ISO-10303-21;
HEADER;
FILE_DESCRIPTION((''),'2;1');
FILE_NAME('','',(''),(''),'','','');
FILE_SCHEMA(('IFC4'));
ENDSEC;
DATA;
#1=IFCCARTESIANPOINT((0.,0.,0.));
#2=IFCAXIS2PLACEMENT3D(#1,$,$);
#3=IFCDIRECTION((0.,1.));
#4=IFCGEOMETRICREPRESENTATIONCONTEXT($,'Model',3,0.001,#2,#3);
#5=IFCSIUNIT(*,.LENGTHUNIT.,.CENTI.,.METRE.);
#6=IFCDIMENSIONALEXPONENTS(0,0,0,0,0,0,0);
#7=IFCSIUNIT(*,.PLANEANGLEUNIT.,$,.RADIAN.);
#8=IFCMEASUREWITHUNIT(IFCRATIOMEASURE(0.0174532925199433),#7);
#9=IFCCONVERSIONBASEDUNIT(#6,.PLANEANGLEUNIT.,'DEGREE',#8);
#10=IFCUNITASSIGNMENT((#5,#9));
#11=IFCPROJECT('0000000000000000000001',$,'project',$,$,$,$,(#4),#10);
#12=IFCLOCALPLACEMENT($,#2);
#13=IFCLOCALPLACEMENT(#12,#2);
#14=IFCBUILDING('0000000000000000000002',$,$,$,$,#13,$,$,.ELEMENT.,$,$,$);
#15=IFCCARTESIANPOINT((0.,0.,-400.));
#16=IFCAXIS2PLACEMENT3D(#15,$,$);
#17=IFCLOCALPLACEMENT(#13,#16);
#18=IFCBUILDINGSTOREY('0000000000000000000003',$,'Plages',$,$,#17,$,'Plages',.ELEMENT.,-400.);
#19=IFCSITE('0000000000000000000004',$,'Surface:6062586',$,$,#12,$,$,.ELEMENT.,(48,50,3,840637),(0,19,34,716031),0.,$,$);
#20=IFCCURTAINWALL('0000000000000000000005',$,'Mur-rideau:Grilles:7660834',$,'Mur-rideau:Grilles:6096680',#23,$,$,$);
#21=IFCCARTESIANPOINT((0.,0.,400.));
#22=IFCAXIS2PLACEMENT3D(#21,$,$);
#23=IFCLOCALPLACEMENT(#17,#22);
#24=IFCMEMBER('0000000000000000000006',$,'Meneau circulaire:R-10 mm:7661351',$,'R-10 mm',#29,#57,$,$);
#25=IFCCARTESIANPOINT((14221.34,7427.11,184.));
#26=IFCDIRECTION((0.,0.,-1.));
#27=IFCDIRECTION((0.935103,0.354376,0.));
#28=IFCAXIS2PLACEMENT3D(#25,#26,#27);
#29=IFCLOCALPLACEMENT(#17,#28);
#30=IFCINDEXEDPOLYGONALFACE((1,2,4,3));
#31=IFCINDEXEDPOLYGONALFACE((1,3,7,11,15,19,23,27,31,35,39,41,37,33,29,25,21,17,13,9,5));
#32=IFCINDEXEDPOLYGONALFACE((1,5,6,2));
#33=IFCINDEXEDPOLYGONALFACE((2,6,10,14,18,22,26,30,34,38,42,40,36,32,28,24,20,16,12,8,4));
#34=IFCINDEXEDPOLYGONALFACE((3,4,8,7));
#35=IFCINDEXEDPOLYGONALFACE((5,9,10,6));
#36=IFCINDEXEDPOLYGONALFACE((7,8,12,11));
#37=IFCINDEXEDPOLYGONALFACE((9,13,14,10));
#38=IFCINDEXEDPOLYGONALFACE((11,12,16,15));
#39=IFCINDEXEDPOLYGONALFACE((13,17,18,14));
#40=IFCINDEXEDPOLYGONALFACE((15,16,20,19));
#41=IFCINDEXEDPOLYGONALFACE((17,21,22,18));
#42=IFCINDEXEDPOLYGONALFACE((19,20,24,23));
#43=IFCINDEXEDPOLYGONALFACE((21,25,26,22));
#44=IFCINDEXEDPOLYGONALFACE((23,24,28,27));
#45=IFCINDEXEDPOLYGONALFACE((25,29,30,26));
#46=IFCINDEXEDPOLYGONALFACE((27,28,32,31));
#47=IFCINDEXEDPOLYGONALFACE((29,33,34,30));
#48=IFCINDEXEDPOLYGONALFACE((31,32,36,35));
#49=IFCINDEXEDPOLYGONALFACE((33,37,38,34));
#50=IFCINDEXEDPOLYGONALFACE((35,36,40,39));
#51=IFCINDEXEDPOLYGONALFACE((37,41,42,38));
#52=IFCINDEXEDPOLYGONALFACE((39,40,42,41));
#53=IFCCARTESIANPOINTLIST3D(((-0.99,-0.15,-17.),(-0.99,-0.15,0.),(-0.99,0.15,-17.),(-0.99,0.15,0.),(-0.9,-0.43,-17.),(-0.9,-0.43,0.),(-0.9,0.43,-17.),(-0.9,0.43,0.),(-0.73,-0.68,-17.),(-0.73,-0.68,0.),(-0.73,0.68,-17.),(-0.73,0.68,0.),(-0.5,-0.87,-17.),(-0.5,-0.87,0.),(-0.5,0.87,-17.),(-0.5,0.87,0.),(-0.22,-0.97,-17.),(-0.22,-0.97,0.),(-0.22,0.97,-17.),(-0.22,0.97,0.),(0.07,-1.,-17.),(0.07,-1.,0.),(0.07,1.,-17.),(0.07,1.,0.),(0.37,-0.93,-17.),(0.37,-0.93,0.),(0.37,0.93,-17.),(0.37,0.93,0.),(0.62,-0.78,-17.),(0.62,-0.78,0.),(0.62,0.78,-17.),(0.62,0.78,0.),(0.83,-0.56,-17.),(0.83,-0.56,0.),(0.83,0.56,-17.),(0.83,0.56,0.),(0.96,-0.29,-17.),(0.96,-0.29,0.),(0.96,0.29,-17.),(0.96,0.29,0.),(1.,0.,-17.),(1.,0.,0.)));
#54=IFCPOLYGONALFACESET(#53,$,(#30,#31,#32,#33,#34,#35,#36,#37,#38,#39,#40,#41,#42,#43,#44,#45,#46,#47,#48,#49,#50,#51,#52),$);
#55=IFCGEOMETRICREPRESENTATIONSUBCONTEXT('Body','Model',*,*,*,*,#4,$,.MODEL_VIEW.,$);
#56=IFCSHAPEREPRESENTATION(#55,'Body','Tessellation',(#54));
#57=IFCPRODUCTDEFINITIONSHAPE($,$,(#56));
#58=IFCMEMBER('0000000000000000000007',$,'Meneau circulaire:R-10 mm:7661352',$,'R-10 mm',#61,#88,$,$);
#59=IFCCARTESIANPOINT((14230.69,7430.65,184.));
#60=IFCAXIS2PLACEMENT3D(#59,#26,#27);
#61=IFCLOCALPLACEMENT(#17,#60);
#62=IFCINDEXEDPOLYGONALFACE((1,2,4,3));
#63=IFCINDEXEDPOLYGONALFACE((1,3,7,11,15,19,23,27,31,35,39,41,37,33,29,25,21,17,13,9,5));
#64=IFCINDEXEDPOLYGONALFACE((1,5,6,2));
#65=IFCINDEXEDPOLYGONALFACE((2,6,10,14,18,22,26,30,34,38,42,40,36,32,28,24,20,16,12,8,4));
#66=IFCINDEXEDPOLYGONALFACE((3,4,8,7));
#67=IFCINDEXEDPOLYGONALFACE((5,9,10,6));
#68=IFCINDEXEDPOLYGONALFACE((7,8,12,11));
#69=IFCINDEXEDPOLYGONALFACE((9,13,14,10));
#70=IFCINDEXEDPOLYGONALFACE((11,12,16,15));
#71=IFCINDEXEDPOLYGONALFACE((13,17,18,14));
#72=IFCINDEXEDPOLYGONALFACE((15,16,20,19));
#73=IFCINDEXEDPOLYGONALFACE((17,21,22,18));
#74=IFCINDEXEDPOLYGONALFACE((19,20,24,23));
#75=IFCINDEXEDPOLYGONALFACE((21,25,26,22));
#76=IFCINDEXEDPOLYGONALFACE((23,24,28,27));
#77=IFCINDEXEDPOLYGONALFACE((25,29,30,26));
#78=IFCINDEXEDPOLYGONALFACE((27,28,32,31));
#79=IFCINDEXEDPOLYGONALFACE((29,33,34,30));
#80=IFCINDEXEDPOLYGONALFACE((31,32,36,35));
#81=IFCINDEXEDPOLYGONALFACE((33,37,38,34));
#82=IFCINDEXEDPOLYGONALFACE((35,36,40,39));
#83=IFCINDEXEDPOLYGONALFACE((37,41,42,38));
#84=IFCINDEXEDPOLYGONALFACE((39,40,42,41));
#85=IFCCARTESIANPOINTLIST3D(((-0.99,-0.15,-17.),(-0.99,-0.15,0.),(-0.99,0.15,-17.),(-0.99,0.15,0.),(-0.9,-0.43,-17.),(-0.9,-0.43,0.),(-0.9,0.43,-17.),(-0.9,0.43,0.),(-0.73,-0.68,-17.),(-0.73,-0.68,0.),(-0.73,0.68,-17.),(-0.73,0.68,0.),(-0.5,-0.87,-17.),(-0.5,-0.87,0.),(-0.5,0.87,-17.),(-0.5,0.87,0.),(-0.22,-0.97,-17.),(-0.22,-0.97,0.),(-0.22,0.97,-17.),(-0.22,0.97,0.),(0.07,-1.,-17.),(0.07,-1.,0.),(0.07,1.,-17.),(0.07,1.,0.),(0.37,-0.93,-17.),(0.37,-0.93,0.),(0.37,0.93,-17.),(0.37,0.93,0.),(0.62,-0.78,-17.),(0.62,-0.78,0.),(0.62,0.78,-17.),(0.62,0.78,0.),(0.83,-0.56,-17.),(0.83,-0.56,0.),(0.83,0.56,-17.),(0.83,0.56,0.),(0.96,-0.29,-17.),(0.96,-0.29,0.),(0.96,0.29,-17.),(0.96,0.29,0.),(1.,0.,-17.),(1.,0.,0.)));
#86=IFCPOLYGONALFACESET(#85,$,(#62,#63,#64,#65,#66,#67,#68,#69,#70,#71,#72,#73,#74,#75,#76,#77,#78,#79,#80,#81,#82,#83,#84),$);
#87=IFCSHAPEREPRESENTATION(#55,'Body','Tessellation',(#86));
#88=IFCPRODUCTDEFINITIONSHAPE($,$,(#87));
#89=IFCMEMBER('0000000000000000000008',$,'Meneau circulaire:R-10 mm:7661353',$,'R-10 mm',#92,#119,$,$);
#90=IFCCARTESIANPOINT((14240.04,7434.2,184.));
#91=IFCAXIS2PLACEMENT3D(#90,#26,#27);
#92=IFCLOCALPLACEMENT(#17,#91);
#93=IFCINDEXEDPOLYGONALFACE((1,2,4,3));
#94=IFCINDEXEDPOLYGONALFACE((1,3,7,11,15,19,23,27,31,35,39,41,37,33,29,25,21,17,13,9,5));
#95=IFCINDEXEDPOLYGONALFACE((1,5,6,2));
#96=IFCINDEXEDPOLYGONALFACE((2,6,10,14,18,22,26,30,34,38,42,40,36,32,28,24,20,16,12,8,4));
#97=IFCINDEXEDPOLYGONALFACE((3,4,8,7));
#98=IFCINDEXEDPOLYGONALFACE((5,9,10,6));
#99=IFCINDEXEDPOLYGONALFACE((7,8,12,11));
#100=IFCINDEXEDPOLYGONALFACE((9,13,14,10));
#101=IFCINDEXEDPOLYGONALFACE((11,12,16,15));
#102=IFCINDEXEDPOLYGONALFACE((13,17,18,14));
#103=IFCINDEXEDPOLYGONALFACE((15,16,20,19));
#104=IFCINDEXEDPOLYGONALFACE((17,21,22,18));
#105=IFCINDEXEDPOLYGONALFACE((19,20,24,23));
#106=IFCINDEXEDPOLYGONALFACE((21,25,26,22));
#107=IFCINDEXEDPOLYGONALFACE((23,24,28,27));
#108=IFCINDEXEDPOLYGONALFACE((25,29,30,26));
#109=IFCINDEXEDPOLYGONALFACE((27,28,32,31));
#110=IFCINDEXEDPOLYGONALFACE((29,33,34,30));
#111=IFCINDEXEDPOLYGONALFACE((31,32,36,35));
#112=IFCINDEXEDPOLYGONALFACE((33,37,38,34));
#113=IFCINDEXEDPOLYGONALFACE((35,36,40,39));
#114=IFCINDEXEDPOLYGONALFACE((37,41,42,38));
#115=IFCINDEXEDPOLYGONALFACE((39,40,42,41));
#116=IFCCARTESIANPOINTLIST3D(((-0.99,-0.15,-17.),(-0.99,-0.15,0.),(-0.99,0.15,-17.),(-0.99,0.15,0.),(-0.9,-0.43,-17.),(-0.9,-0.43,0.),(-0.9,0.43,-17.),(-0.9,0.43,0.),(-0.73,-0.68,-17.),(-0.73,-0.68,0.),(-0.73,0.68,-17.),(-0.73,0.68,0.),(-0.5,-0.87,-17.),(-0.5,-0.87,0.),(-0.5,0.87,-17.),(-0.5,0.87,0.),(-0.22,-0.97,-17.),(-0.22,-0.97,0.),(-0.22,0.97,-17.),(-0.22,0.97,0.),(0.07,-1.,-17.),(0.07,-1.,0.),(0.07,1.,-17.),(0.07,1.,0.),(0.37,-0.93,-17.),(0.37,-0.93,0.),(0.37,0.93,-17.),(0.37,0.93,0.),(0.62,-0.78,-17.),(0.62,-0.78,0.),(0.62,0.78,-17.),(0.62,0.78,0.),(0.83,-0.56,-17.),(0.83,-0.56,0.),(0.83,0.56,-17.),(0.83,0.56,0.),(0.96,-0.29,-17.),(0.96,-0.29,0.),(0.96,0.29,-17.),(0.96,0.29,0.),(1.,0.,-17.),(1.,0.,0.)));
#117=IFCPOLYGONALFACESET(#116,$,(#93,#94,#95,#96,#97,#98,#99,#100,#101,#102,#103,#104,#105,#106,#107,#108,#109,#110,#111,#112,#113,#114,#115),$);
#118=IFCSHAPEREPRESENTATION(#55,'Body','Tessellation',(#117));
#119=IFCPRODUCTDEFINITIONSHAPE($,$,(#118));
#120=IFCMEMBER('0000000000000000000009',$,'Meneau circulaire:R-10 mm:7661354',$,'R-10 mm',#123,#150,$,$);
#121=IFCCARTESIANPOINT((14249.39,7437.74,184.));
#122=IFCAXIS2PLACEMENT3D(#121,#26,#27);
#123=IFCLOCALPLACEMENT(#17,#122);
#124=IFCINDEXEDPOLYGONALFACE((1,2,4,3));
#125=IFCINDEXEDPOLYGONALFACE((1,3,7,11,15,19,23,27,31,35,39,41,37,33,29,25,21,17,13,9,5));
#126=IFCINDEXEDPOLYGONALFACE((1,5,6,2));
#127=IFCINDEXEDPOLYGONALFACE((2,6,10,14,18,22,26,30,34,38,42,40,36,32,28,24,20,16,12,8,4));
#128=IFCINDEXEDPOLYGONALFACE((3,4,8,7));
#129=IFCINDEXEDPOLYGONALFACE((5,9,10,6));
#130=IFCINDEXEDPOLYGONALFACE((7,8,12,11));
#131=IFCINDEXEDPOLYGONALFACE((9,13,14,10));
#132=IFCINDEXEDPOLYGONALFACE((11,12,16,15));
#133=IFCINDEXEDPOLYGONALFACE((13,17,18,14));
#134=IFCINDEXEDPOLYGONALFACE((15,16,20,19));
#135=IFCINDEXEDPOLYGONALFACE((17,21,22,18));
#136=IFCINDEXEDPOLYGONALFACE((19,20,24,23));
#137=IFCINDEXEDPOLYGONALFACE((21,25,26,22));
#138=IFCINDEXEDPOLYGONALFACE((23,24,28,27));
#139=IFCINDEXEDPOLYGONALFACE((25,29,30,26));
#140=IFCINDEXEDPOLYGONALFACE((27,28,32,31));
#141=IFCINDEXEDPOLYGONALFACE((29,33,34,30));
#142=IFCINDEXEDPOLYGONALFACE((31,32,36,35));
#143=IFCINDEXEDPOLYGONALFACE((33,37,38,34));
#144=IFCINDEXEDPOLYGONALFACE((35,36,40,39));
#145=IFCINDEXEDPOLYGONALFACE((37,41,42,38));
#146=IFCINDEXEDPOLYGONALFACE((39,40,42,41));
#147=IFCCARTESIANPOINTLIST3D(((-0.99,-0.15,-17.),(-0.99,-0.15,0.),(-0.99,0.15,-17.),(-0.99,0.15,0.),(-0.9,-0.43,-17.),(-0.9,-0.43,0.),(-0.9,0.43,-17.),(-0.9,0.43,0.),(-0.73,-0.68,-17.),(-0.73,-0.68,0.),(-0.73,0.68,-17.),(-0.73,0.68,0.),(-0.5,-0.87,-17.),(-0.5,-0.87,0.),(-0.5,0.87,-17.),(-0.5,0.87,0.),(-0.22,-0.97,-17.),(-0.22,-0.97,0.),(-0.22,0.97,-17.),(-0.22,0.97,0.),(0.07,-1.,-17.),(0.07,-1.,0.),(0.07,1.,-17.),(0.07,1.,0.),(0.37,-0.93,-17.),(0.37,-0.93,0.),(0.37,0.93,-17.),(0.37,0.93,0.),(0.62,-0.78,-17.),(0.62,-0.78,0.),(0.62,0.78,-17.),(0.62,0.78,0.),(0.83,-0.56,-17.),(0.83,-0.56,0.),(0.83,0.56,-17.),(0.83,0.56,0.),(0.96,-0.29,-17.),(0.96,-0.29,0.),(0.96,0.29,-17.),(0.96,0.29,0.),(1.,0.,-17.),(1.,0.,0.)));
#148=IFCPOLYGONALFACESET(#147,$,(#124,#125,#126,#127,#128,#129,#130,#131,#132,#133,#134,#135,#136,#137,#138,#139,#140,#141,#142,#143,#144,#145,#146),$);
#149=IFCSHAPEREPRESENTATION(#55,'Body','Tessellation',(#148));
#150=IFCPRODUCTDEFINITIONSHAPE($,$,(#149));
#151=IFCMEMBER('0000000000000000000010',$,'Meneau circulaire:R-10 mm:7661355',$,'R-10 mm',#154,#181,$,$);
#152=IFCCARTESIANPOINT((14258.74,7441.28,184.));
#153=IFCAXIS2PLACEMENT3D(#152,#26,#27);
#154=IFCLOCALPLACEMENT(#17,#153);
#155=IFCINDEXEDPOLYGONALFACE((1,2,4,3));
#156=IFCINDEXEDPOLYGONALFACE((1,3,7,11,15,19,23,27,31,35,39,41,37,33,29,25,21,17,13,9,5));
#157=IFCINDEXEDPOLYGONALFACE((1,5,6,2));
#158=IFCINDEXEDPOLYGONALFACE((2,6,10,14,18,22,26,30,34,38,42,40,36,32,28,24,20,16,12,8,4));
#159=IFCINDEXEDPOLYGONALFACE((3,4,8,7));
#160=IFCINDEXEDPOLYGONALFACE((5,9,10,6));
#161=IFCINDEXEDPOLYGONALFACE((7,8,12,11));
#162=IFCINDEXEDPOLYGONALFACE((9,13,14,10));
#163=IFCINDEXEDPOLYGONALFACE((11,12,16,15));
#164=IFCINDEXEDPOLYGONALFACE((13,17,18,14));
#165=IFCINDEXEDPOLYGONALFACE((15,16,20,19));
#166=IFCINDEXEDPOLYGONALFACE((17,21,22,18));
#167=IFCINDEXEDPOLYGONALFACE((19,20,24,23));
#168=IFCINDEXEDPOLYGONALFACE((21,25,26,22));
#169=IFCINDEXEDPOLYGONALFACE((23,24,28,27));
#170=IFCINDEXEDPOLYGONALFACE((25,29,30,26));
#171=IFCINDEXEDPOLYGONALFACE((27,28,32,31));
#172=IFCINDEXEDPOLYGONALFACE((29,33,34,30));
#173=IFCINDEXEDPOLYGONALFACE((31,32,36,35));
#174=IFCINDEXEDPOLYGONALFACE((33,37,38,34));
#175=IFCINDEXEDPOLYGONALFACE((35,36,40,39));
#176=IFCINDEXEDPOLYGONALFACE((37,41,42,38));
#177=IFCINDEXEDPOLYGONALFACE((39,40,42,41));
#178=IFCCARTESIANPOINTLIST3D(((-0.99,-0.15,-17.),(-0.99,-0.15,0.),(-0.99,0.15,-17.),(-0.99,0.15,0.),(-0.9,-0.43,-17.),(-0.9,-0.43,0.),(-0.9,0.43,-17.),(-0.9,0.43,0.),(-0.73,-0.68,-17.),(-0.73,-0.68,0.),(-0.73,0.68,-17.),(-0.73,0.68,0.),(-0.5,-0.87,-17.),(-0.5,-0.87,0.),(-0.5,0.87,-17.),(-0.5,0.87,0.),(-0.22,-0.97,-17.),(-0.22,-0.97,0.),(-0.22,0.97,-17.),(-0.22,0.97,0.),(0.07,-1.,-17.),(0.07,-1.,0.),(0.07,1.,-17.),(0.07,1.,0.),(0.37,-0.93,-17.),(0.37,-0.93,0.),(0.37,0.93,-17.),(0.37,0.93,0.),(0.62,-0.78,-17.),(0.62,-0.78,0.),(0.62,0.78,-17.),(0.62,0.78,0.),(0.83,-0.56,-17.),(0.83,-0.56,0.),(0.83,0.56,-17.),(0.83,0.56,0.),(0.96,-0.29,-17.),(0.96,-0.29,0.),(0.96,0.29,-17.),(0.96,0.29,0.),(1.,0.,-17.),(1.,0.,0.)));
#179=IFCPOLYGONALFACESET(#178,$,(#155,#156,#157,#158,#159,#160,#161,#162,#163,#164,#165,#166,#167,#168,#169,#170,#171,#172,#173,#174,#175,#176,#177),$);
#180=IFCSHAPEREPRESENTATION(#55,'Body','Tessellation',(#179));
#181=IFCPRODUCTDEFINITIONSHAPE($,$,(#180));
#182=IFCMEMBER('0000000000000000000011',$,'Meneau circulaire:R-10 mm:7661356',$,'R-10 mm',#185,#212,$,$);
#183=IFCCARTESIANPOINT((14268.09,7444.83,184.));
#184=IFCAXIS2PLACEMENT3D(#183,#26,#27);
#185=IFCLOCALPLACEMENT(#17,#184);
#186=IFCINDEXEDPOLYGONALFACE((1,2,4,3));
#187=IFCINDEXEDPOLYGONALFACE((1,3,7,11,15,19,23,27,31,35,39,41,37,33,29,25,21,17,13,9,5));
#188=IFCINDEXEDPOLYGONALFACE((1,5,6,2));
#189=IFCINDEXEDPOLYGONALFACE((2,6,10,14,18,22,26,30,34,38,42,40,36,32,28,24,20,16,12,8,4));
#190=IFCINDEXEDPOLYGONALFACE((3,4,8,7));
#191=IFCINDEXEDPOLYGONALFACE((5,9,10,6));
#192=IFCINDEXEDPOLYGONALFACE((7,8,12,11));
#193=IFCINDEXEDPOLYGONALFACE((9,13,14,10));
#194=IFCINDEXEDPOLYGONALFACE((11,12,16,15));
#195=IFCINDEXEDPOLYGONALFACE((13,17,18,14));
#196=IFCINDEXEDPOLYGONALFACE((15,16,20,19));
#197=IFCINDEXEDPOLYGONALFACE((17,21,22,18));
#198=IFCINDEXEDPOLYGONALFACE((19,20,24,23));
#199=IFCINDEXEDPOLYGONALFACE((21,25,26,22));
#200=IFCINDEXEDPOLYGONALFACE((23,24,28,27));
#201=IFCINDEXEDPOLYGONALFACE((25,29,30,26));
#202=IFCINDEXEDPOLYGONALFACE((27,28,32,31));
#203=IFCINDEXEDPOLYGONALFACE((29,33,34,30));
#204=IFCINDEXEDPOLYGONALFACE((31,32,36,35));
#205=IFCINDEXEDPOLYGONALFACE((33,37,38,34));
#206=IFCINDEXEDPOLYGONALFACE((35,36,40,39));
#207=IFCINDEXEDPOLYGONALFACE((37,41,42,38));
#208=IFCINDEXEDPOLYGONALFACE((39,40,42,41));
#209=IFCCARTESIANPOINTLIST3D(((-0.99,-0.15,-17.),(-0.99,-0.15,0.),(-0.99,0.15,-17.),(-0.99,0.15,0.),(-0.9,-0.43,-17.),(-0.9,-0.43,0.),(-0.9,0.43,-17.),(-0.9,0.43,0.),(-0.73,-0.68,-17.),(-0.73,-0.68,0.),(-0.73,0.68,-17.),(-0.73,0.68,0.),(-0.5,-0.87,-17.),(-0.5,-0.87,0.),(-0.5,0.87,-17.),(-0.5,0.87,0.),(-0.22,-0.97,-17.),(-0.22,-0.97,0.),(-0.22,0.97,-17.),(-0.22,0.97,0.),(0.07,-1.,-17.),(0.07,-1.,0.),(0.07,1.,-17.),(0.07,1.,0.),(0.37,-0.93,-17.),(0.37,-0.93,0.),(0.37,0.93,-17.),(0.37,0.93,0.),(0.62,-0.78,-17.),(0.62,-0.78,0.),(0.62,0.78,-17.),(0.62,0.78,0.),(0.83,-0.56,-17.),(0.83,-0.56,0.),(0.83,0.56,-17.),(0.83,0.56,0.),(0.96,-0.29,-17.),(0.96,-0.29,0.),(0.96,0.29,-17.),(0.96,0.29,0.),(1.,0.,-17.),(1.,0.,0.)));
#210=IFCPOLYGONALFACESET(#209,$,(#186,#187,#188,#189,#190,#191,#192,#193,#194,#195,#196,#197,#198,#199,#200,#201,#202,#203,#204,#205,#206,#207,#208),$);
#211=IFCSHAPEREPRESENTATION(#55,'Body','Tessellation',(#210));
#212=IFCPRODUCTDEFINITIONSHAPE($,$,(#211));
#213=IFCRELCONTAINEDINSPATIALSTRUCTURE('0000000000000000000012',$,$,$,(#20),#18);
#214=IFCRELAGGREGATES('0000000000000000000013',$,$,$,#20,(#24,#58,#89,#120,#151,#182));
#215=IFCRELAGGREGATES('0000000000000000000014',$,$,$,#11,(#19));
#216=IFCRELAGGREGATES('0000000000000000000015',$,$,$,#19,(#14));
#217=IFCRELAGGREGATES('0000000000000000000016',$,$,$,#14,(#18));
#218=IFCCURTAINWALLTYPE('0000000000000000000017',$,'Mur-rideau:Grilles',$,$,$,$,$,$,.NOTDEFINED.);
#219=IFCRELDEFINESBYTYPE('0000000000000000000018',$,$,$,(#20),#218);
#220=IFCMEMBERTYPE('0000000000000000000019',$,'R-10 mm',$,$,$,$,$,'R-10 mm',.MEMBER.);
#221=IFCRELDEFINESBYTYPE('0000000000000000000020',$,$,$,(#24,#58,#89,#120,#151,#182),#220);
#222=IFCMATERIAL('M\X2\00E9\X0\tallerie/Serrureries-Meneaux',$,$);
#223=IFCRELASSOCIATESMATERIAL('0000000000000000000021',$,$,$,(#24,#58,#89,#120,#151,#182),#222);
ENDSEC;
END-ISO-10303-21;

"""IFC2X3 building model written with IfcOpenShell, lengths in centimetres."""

from ifc_helpers import new_model, entity, si_unit, converted_unit, direction, frame, frame_2d, origin, place, context, subcontext, project, spatial, circle, extrude, source, transform, mapped, material, type_object, type_shapes, element, aggregate, save


model = new_model("IFC2X3")

# Units and contexts
model_context = context("Model", 3, precision=0.001, world=origin(), true_north=direction((0.0, 1.0)))
body_context = subcontext(model_context, "Body", "Model", "MODEL_VIEW")
ifc_project = project(units=[si_unit("LENGTHUNIT", "METRE", prefix="CENTI"), converted_unit("PLANEANGLEUNIT", "DEGREE", entity("IfcRatioMeasure", 0.0174532925199433), si_unit("PLANEANGLEUNIT", "RADIAN"), dimensions=[0, 0, 0, 0, 0, 0, 0])], contexts=[model_context])

# Site, building, storey
site_placement = place(None, origin())
site = spatial("IfcSite", under=ifc_project, at=site_placement, Name="Surface:6062586", CompositionType="ELEMENT", RefLatitude=(48, 50, 3, 840637), RefLongitude=(0, 19, 34, 716031), RefElevation=0.0)
building_placement = place(site_placement, origin())
building = spatial("IfcBuilding", under=site, at=building_placement, CompositionType="ELEMENT")
storey_placement = place(building_placement, frame((0.0, 0.0, -400.0)))
storey = spatial("IfcBuildingStorey", under=building, at=storey_placement, Name="Plages", LongName="Plages", CompositionType="ELEMENT", Elevation=-400.0)

# Curtain wall, members
curtain_wall_type = type_object("IfcCurtainWallType", Name="Mur-rideau:Grilles", PredefinedType="NOTDEFINED")
curtain_wall_placement = place(storey_placement, frame((0.0, 0.0, 400.0)))
curtain_wall = element("IfcCurtainWall", 1, at=curtain_wall_placement, inside=storey, type_object=curtain_wall_type, Name="Mur-rideau:Grilles:7660834", ObjectType="Mur-rideau:Grilles:6096680")
ifc_material = material(Name="Métallerie/Serrureries-Meneaux")
member_type_1 = type_object("IfcMemberType", Name="R-10 mm", ElementType="R-10 mm", PredefinedType="MEMBER")
shared_shape_1 = source(origin(), body_context, "Body", "SweptSolid", [
    extrude(circle(Radius=1.0, at=frame_2d((0.0, 0.0), x_axis=(1.0, 0.0))), frame((0.0, 0.0, -17.0)), (0.0, 0.0, 1.0), 17.0),
])
type_shapes(member_type_1, [shared_shape_1])
member_1_placement = place(storey_placement, frame((14221.34, 7427.11, 184.0), z_axis=(0.0, 0.0, -1.0), x_axis=(0.935103, 0.354376, 0.0)))
member_1 = element("IfcMember", 2, at=member_1_placement, type_object=member_type_1, material=ifc_material, Name="Meneau circulaire:R-10 mm:7661351", ObjectType="R-10 mm", context=body_context, shape_type="MappedRepresentation", body=[
    mapped(shared_shape_1, transform((0.0, 0.0, 0.0), scale=1.0)),
])
member_2_placement = place(storey_placement, frame((14230.69, 7430.65, 184.0), z_axis=(0.0, 0.0, -1.0), x_axis=(0.935103, 0.354376, 0.0)))
member_2 = element("IfcMember", 3, at=member_2_placement, type_object=member_type_1, material=ifc_material, Name="Meneau circulaire:R-10 mm:7661352", ObjectType="R-10 mm", context=body_context, shape_type="MappedRepresentation", body=[
    mapped(shared_shape_1, transform((0.0, 0.0, 0.0), scale=1.0)),
])
member_3_placement = place(storey_placement, frame((14240.04, 7434.2, 184.0), z_axis=(0.0, 0.0, -1.0), x_axis=(0.935103, 0.354376, 0.0)))
member_3 = element("IfcMember", 4, at=member_3_placement, type_object=member_type_1, material=ifc_material, Name="Meneau circulaire:R-10 mm:7661353", ObjectType="R-10 mm", context=body_context, shape_type="MappedRepresentation", body=[
    mapped(shared_shape_1, transform((0.0, 0.0, 0.0), scale=1.0)),
])
member_4_placement = place(storey_placement, frame((14249.39, 7437.74, 184.0), z_axis=(0.0, 0.0, -1.0), x_axis=(0.935103, 0.354376, 0.0)))
member_4 = element("IfcMember", 5, at=member_4_placement, type_object=member_type_1, material=ifc_material, Name="Meneau circulaire:R-10 mm:7661354", ObjectType="R-10 mm", context=body_context, shape_type="MappedRepresentation", body=[
    mapped(shared_shape_1, transform((0.0, 0.0, 0.0), scale=1.0)),
])
member_5_placement = place(storey_placement, frame((14258.74, 7441.28, 184.0), z_axis=(0.0, 0.0, -1.0), x_axis=(0.935103, 0.354376, 0.0)))
member_5 = element("IfcMember", 6, at=member_5_placement, type_object=member_type_1, material=ifc_material, Name="Meneau circulaire:R-10 mm:7661355", ObjectType="R-10 mm", context=body_context, shape_type="MappedRepresentation", body=[
    mapped(shared_shape_1, transform((0.0, 0.0, 0.0), scale=1.0)),
])
member_6_placement = place(storey_placement, frame((14268.09, 7444.83, 184.0), z_axis=(0.0, 0.0, -1.0), x_axis=(0.935103, 0.354376, 0.0)))
member_6 = element("IfcMember", 7, at=member_6_placement, type_object=member_type_1, material=ifc_material, Name="Meneau circulaire:R-10 mm:7661356", ObjectType="R-10 mm", context=body_context, shape_type="MappedRepresentation", body=[
    mapped(shared_shape_1, transform((0.0, 0.0, 0.0), scale=1.0)),
])
aggregate(curtain_wall, [member_1, member_2, member_3, member_4, member_5, member_6])

save(model, "model.ifc")
